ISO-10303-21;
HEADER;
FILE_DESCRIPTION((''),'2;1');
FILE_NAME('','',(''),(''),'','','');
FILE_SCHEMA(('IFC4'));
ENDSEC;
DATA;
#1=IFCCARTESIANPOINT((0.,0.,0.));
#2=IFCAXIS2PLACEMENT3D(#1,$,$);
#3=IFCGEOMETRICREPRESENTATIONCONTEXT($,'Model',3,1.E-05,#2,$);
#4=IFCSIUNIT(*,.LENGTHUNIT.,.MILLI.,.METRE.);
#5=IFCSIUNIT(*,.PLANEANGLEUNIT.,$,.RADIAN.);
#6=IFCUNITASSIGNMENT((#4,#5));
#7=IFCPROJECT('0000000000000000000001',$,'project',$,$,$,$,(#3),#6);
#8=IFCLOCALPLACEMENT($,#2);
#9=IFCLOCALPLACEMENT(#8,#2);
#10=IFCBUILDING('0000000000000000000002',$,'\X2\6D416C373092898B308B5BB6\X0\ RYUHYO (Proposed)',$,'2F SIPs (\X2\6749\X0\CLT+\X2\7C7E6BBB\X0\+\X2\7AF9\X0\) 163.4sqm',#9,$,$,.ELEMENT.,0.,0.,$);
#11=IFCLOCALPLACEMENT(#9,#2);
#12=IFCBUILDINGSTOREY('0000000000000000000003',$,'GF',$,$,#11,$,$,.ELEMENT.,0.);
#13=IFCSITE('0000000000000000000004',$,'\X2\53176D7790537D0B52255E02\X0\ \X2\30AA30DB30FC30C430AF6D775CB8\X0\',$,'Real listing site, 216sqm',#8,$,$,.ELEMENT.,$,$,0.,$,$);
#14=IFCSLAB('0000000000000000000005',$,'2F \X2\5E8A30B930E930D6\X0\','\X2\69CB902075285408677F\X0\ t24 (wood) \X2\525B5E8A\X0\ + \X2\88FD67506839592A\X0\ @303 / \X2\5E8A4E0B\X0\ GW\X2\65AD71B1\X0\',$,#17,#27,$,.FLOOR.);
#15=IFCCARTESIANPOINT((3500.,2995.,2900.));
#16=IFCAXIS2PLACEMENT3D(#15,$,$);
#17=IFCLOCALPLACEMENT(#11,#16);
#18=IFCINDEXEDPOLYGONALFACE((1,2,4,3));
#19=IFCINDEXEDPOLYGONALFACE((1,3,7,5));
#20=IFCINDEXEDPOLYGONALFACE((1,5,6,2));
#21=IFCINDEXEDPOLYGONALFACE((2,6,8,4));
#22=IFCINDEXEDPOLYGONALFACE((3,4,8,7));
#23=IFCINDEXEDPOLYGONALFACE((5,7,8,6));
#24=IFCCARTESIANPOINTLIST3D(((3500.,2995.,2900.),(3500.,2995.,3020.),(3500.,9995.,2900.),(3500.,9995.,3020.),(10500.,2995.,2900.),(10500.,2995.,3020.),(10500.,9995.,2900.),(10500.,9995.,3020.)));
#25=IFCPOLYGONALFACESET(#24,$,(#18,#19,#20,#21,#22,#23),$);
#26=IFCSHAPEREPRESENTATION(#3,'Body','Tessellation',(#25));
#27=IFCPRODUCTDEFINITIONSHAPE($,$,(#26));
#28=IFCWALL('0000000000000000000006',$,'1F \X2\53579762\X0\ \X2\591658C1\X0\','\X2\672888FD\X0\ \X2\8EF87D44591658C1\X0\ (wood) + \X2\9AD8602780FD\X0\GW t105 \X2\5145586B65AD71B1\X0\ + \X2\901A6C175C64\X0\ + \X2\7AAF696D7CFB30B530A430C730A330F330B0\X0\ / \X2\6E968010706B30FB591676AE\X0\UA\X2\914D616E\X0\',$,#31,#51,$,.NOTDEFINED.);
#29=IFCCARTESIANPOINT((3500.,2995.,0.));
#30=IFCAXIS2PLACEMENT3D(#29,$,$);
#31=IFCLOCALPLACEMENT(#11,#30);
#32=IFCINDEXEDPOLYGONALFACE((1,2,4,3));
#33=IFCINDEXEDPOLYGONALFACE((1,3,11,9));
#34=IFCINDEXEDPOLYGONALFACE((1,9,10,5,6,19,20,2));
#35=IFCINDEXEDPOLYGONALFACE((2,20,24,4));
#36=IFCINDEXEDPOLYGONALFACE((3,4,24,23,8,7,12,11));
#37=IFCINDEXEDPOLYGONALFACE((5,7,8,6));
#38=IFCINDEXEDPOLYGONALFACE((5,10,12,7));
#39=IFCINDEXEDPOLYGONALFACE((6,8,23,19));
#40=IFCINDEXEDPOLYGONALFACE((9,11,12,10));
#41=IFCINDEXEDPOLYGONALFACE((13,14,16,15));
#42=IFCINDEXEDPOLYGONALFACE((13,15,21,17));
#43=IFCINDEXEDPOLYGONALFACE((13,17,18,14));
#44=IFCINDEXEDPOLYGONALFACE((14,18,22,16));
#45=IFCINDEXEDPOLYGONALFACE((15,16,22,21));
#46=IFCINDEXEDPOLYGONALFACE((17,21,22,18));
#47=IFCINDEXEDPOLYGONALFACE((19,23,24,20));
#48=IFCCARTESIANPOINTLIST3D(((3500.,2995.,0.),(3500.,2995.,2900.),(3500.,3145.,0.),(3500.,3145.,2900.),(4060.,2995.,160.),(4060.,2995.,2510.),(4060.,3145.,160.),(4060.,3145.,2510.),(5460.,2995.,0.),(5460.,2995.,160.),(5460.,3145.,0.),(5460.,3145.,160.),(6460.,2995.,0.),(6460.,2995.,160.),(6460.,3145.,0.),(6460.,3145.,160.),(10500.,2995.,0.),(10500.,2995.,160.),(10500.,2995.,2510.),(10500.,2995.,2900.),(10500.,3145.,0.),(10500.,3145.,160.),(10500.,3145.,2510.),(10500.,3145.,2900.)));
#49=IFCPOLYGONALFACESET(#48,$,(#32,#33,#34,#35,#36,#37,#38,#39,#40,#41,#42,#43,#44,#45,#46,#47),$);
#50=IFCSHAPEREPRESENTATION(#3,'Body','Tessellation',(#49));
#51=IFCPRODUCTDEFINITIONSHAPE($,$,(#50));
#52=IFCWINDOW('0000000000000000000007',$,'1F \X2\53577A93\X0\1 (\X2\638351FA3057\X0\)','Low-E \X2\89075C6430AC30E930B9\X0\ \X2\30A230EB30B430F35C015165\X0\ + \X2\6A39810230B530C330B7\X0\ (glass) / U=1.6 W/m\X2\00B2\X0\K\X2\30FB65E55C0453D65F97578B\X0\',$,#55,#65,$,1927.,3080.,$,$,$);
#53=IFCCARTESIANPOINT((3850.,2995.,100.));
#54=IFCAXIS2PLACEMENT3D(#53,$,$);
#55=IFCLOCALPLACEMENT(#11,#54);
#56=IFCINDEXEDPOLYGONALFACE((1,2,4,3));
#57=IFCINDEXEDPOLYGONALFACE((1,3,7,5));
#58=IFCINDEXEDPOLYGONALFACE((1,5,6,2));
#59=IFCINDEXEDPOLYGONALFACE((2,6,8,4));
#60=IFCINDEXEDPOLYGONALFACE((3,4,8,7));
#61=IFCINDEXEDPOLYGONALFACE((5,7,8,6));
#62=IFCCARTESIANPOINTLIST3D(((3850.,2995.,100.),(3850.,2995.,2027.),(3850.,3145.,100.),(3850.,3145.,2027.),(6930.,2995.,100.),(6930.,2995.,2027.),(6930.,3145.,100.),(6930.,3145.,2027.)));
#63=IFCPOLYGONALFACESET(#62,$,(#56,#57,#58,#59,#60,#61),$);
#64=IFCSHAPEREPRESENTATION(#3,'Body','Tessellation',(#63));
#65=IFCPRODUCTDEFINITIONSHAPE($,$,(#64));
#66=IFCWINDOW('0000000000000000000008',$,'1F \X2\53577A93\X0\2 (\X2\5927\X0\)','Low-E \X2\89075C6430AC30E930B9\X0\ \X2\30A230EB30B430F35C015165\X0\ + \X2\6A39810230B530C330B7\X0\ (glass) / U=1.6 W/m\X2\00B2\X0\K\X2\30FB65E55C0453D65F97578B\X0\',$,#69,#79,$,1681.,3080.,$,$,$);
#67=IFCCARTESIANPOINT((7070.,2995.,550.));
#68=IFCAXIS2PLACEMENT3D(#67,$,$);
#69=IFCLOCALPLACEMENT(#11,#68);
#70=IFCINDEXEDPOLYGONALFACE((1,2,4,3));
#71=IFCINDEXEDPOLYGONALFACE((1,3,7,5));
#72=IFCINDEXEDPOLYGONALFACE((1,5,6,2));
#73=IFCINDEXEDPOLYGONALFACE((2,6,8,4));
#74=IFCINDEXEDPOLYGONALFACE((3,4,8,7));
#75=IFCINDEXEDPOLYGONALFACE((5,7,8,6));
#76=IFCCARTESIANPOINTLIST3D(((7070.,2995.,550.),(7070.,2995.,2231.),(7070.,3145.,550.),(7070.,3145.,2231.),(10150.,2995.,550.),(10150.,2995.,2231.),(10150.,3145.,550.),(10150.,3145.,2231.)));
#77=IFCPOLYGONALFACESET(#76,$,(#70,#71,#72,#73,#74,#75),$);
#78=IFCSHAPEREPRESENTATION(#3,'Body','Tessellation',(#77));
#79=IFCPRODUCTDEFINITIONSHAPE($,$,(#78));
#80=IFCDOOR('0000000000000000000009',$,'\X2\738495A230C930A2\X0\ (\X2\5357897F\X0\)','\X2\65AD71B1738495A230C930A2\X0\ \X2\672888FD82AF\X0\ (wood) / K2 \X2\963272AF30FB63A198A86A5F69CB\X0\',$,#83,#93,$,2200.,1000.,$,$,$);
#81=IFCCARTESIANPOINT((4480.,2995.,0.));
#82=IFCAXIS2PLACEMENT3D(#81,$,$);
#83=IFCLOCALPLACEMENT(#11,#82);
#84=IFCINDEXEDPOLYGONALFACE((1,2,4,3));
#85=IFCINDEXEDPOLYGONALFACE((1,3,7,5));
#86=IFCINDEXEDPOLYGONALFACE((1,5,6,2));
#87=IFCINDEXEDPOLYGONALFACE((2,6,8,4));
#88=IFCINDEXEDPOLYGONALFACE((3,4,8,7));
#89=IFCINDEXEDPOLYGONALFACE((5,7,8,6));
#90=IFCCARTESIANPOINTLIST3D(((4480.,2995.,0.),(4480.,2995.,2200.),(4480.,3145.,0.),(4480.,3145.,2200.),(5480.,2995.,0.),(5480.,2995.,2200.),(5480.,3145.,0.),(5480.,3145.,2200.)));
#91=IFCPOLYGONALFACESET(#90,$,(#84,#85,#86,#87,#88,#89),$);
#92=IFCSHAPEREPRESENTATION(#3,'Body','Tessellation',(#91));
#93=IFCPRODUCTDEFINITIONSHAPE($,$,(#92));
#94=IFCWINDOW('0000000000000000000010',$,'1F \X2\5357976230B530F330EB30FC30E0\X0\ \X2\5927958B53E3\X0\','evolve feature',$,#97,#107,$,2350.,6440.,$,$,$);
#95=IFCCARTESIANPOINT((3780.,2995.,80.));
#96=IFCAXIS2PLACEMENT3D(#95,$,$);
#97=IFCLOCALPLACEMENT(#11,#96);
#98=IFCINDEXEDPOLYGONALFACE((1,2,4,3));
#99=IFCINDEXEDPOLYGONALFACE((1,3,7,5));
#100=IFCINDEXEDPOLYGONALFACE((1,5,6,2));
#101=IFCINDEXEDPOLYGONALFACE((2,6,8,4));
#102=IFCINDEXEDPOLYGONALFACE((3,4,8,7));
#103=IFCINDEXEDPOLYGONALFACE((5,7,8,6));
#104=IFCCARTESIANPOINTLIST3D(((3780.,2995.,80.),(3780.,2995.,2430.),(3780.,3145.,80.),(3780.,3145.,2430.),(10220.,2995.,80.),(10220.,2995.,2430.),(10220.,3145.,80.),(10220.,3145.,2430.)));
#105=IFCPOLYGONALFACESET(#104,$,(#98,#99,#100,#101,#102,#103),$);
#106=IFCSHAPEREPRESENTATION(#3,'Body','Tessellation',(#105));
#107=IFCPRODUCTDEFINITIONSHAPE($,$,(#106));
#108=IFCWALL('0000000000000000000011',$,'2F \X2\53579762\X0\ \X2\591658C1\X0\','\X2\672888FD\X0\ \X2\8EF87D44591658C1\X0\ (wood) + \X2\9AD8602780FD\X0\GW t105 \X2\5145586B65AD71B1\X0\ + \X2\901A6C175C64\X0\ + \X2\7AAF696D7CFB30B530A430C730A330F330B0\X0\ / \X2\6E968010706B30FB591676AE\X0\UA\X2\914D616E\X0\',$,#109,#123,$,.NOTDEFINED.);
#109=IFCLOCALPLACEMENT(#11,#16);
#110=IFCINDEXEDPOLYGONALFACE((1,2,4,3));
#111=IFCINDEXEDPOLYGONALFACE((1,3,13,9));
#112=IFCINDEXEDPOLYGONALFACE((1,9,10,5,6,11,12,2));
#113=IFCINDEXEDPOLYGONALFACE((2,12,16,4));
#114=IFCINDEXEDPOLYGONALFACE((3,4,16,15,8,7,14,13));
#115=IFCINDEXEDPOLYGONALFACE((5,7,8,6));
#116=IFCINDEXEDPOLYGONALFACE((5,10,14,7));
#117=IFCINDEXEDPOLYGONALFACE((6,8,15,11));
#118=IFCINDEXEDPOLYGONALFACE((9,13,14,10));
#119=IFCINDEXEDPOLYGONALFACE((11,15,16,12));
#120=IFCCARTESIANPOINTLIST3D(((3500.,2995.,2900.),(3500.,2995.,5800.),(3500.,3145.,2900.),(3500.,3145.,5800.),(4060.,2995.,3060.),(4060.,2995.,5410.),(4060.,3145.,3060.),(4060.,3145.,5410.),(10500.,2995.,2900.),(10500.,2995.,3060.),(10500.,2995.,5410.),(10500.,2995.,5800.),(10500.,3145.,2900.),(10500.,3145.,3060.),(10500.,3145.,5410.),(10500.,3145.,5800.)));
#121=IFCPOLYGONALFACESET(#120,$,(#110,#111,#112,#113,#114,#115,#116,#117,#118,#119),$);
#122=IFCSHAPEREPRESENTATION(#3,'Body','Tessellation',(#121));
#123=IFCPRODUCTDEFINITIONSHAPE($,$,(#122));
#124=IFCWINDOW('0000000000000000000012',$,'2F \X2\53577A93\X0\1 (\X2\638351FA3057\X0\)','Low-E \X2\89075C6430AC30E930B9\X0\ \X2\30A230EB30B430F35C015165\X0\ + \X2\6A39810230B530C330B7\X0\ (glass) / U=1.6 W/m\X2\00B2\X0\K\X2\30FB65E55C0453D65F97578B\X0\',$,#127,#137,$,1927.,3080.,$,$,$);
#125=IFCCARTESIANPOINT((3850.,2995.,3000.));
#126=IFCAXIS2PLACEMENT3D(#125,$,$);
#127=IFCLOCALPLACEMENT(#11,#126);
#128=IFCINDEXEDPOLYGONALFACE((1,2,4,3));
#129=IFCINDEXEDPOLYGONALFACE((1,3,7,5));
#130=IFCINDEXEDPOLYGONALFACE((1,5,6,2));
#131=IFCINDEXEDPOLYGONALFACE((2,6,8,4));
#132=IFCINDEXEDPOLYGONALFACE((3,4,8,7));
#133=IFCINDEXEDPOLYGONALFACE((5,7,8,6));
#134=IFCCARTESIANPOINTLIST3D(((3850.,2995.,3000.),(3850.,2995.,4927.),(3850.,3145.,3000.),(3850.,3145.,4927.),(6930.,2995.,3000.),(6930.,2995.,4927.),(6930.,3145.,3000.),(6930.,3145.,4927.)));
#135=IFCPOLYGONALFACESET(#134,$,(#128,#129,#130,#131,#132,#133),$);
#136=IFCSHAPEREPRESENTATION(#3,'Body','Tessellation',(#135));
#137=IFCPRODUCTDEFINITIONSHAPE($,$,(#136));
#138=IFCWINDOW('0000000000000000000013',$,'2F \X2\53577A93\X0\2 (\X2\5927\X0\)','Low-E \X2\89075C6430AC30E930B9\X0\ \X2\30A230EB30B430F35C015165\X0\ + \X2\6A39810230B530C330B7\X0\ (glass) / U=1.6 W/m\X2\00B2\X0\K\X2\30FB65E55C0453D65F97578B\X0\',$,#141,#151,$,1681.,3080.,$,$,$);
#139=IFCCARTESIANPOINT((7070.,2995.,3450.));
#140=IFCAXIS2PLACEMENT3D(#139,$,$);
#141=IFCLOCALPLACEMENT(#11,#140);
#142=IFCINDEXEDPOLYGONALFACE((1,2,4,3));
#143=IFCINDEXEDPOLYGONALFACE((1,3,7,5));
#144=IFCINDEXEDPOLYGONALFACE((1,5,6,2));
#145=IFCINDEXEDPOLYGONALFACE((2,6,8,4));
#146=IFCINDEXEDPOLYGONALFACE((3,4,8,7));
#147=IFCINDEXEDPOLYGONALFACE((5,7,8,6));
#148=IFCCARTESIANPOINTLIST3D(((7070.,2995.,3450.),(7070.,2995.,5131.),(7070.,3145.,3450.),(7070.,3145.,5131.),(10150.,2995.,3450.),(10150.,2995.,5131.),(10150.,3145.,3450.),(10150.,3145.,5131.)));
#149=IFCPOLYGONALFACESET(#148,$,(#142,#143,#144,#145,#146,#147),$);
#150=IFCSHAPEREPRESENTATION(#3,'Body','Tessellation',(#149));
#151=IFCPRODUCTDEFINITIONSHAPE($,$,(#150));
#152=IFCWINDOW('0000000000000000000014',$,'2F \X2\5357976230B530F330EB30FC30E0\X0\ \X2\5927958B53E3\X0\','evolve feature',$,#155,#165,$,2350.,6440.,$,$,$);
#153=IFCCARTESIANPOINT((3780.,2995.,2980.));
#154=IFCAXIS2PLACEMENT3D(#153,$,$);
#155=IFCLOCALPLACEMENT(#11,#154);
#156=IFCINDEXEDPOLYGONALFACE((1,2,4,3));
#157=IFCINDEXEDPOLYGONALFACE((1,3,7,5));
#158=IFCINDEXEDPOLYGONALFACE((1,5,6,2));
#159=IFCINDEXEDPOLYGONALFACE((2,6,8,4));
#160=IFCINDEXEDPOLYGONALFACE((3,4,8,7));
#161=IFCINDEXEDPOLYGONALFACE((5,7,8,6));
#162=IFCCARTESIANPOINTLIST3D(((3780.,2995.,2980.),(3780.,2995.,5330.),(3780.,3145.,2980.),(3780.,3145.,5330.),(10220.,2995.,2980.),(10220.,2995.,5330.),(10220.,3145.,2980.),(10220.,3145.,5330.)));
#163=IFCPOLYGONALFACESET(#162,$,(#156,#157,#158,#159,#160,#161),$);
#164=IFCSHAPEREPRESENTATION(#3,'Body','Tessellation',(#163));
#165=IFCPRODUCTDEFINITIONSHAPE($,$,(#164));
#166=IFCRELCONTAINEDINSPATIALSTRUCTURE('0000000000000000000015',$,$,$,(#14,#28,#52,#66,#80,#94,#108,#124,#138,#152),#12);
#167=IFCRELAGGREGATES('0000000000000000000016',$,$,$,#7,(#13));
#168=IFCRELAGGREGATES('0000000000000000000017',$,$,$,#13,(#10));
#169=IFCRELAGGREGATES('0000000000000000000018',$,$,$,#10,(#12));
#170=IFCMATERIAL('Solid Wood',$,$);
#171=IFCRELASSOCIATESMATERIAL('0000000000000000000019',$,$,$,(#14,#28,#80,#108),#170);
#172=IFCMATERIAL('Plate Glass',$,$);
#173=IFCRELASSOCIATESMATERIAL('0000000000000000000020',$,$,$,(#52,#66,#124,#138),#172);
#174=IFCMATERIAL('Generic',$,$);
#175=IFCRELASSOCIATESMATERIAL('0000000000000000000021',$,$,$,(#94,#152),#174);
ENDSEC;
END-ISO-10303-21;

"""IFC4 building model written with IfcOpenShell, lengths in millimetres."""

from ifc_helpers import new_model, si_unit, frame, frame_2d, origin, place, context, project, spatial, rectangle, extrude, material, element, fill, save


model = new_model("IFC4")

# Units and contexts
model_context = context("Model", 3, precision=1e-05, world=origin())
ifc_project = project(units=[si_unit("LENGTHUNIT", "METRE", prefix="MILLI"), si_unit("PLANEANGLEUNIT", "RADIAN")], contexts=[model_context])

# Site, building, storey
site_placement = place(None, origin())
site = spatial("IfcSite", under=ifc_project, at=site_placement, Name="北海道紋別市 オホーツク海岸", ObjectType="Real listing site, 216sqm", CompositionType="ELEMENT", RefElevation=0.0)
building_placement = place(site_placement, origin())
building = spatial("IfcBuilding", under=site, at=building_placement, Name="流氷を見る家 RYUHYO (Proposed)", ObjectType="2F SIPs (杉CLT+籾殻+竹) 163.4sqm", CompositionType="ELEMENT", ElevationOfRefHeight=0.0, ElevationOfTerrain=0.0)
storey_placement = place(building_placement, origin())
storey = spatial("IfcBuildingStorey", under=building, at=storey_placement, Name="GF", CompositionType="ELEMENT", Elevation=0.0)

# Slab
ifc_material_1 = material(Name="Solid Wood")
slab_1_placement = place(storey_placement, frame((3500.0, 2995.0, 2900.0)))
element("IfcSlab", 1, at=slab_1_placement, inside=storey, material=ifc_material_1, Name="2F 床スラブ", Description="構造用合板 t24 (wood) 剛床 + 製材根太 @303 / 床下 GW断熱", PredefinedType="FLOOR", context=model_context, shape_type="SweptSolid", body=[
    extrude(rectangle(XDim=7000.0, YDim=7000.0, at=frame_2d((3500.0, 3500.0))), frame((3500.0, 2995.0, 2900.0)), (0.0, 0.0, 1.0), 120.0),
])
ifc_material_2 = material(Name="Generic")

# Wall, openings, windows, door
wall_1_placement = place(storey_placement, frame((3500.0, 2995.0, 0.0)))
wall_1 = element("IfcWall", 2, at=wall_1_placement, inside=storey, material=ifc_material_1, Name="1F 南面 外壁", Description="木製 軸組外壁 (wood) + 高性能GW t105 充填断熱 + 通気層 + 窯業系サイディング / 準耐火・外皮UA配慮", PredefinedType="NOTDEFINED", context=model_context, shape_type="SweptSolid", body=[
    extrude(rectangle(XDim=7000.0, YDim=150.0, at=frame_2d((3500.0, 75.0))), frame((3500.0, 2995.0, 0.0)), (0.0, 0.0, 1.0), 2900.0),
])
opening_1_placement = place(storey_placement, frame((3850.0, 2995.0, 100.0)))
opening_1 = element("IfcOpeningElement", 3, at=opening_1_placement, cuts=wall_1, PredefinedType="NOTDEFINED", context=model_context, shape_type="SweptSolid", body=[
    extrude(rectangle(XDim=3080.0, YDim=150.0, at=frame_2d((1540.0, 75.0))), frame((3850.0, 2995.0, 100.0)), (0.0, 0.0, 1.0), 1927.0),
])
opening_2_placement = place(storey_placement, frame((7070.0, 2995.0, 550.0)))
opening_2 = element("IfcOpeningElement", 4, at=opening_2_placement, cuts=wall_1, PredefinedType="NOTDEFINED", context=model_context, shape_type="SweptSolid", body=[
    extrude(rectangle(XDim=3080.0, YDim=150.0, at=frame_2d((1540.0, 75.0))), frame((7070.0, 2995.0, 550.0)), (0.0, 0.0, 1.0), 1681.0),
])
opening_3_placement = place(storey_placement, frame((4480.0, 2995.0, 0.0)))
opening_3 = element("IfcOpeningElement", 5, at=opening_3_placement, cuts=wall_1, PredefinedType="NOTDEFINED", context=model_context, shape_type="SweptSolid", body=[
    extrude(rectangle(XDim=1000.0, YDim=150.0, at=frame_2d((500.0, 75.0))), frame((4480.0, 2995.0, 0.0)), (0.0, 0.0, 1.0), 2200.0),
])
opening_4_placement = place(storey_placement, frame((3780.0, 2995.0, 80.0)))
opening_4 = element("IfcOpeningElement", 6, at=opening_4_placement, cuts=wall_1, PredefinedType="NOTDEFINED", context=model_context, shape_type="SweptSolid", body=[
    extrude(rectangle(XDim=6440.0, YDim=150.0, at=frame_2d((3220.0, 75.0))), frame((3780.0, 2995.0, 80.0)), (0.0, 0.0, 1.0), 2350.0),
])
ifc_material_3 = material(Name="Plate Glass")
window_1_placement = place(storey_placement, frame((3850.0, 2995.0, 100.0)))
window_1 = element("IfcWindow", 7, at=window_1_placement, inside=storey, material=ifc_material_3, Name="1F 南窓1 (掃出し)", Description="Low-E 複層ガラス アルゴン封入 + 樹脂サッシ (glass) / U=1.6 W/m²K・日射取得型", OverallHeight=1927.0, OverallWidth=3080.0, context=model_context, shape_type="SweptSolid", body=[
    extrude(rectangle(XDim=3080.0, YDim=150.0, at=frame_2d((1540.0, 75.0))), frame((3850.0, 2995.0, 100.0)), (0.0, 0.0, 1.0), 1927.0),
])
fill(opening_1, window_1)
window_2_placement = place(storey_placement, frame((7070.0, 2995.0, 550.0)))
window_2 = element("IfcWindow", 8, at=window_2_placement, inside=storey, material=ifc_material_3, Name="1F 南窓2 (大)", Description="Low-E 複層ガラス アルゴン封入 + 樹脂サッシ (glass) / U=1.6 W/m²K・日射取得型", OverallHeight=1681.0, OverallWidth=3080.0, context=model_context, shape_type="SweptSolid", body=[
    extrude(rectangle(XDim=3080.0, YDim=150.0, at=frame_2d((1540.0, 75.0))), frame((7070.0, 2995.0, 550.0)), (0.0, 0.0, 1.0), 1681.0),
])
fill(opening_2, window_2)
door_placement = place(storey_placement, frame((4480.0, 2995.0, 0.0)))
door = element("IfcDoor", 9, at=door_placement, inside=storey, material=ifc_material_1, Name="玄関ドア (南西)", Description="断熱玄関ドア 木製芯 (wood) / K2 防犯・採風機構", OverallHeight=2200.0, OverallWidth=1000.0, context=model_context, shape_type="SweptSolid", body=[
    extrude(rectangle(XDim=1000.0, YDim=150.0, at=frame_2d((500.0, 75.0))), frame((4480.0, 2995.0, 0.0)), (0.0, 0.0, 1.0), 2200.0),
])
fill(opening_3, door)
window_3_placement = place(storey_placement, frame((3780.0, 2995.0, 80.0)))
window_3 = element("IfcWindow", 10, at=window_3_placement, inside=storey, material=ifc_material_2, Name="1F 南面サンルーム 大開口", Description="evolve feature", OverallHeight=2350.0, OverallWidth=6440.0, context=model_context, shape_type="SweptSolid", body=[
    extrude(rectangle(XDim=6440.0, YDim=150.0, at=frame_2d((3220.0, 75.0))), frame((3780.0, 2995.0, 80.0)), (0.0, 0.0, 1.0), 2350.0),
])
fill(opening_4, window_3)

# Wall, openings, windows
wall_2_placement = place(storey_placement, frame((3500.0, 2995.0, 2900.0)))
wall_2 = element("IfcWall", 11, at=wall_2_placement, inside=storey, material=ifc_material_1, Name="2F 南面 外壁", Description="木製 軸組外壁 (wood) + 高性能GW t105 充填断熱 + 通気層 + 窯業系サイディング / 準耐火・外皮UA配慮", PredefinedType="NOTDEFINED", context=model_context, shape_type="SweptSolid", body=[
    extrude(rectangle(XDim=7000.0, YDim=150.0, at=frame_2d((3500.0, 75.0))), frame((3500.0, 2995.0, 2900.0)), (0.0, 0.0, 1.0), 2900.0),
])
opening_5_placement = place(storey_placement, frame((3850.0, 2995.0, 3000.0)))
opening_5 = element("IfcOpeningElement", 12, at=opening_5_placement, cuts=wall_2, PredefinedType="NOTDEFINED", context=model_context, shape_type="SweptSolid", body=[
    extrude(rectangle(XDim=3080.0, YDim=150.0, at=frame_2d((1540.0, 75.0))), frame((3850.0, 2995.0, 3000.0)), (0.0, 0.0, 1.0), 1927.0),
])
opening_6_placement = place(storey_placement, frame((7070.0, 2995.0, 3450.0)))
opening_6 = element("IfcOpeningElement", 13, at=opening_6_placement, cuts=wall_2, PredefinedType="NOTDEFINED", context=model_context, shape_type="SweptSolid", body=[
    extrude(rectangle(XDim=3080.0, YDim=150.0, at=frame_2d((1540.0, 75.0))), frame((7070.0, 2995.0, 3450.0)), (0.0, 0.0, 1.0), 1681.0),
])
opening_7_placement = place(storey_placement, frame((3780.0, 2995.0, 2980.0)))
opening_7 = element("IfcOpeningElement", 14, at=opening_7_placement, cuts=wall_2, PredefinedType="NOTDEFINED", context=model_context, shape_type="SweptSolid", body=[
    extrude(rectangle(XDim=6440.0, YDim=150.0, at=frame_2d((3220.0, 75.0))), frame((3780.0, 2995.0, 2980.0)), (0.0, 0.0, 1.0), 2350.0),
])
window_4_placement = place(storey_placement, frame((3850.0, 2995.0, 3000.0)))
window_4 = element("IfcWindow", 15, at=window_4_placement, inside=storey, material=ifc_material_3, Name="2F 南窓1 (掃出し)", Description="Low-E 複層ガラス アルゴン封入 + 樹脂サッシ (glass) / U=1.6 W/m²K・日射取得型", OverallHeight=1927.0, OverallWidth=3080.0, context=model_context, shape_type="SweptSolid", body=[
    extrude(rectangle(XDim=3080.0, YDim=150.0, at=frame_2d((1540.0, 75.0))), frame((3850.0, 2995.0, 3000.0)), (0.0, 0.0, 1.0), 1927.0),
])
fill(opening_5, window_4)
window_5_placement = place(storey_placement, frame((7070.0, 2995.0, 3450.0)))
window_5 = element("IfcWindow", 16, at=window_5_placement, inside=storey, material=ifc_material_3, Name="2F 南窓2 (大)", Description="Low-E 複層ガラス アルゴン封入 + 樹脂サッシ (glass) / U=1.6 W/m²K・日射取得型", OverallHeight=1681.0, OverallWidth=3080.0, context=model_context, shape_type="SweptSolid", body=[
    extrude(rectangle(XDim=3080.0, YDim=150.0, at=frame_2d((1540.0, 75.0))), frame((7070.0, 2995.0, 3450.0)), (0.0, 0.0, 1.0), 1681.0),
])
fill(opening_6, window_5)
window_6_placement = place(storey_placement, frame((3780.0, 2995.0, 2980.0)))
window_6 = element("IfcWindow", 17, at=window_6_placement, inside=storey, material=ifc_material_2, Name="2F 南面サンルーム 大開口", Description="evolve feature", OverallHeight=2350.0, OverallWidth=6440.0, context=model_context, shape_type="SweptSolid", body=[
    extrude(rectangle(XDim=6440.0, YDim=150.0, at=frame_2d((3220.0, 75.0))), frame((3780.0, 2995.0, 2980.0)), (0.0, 0.0, 1.0), 2350.0),
])
fill(opening_7, window_6)

save(model, "model.ifc")
